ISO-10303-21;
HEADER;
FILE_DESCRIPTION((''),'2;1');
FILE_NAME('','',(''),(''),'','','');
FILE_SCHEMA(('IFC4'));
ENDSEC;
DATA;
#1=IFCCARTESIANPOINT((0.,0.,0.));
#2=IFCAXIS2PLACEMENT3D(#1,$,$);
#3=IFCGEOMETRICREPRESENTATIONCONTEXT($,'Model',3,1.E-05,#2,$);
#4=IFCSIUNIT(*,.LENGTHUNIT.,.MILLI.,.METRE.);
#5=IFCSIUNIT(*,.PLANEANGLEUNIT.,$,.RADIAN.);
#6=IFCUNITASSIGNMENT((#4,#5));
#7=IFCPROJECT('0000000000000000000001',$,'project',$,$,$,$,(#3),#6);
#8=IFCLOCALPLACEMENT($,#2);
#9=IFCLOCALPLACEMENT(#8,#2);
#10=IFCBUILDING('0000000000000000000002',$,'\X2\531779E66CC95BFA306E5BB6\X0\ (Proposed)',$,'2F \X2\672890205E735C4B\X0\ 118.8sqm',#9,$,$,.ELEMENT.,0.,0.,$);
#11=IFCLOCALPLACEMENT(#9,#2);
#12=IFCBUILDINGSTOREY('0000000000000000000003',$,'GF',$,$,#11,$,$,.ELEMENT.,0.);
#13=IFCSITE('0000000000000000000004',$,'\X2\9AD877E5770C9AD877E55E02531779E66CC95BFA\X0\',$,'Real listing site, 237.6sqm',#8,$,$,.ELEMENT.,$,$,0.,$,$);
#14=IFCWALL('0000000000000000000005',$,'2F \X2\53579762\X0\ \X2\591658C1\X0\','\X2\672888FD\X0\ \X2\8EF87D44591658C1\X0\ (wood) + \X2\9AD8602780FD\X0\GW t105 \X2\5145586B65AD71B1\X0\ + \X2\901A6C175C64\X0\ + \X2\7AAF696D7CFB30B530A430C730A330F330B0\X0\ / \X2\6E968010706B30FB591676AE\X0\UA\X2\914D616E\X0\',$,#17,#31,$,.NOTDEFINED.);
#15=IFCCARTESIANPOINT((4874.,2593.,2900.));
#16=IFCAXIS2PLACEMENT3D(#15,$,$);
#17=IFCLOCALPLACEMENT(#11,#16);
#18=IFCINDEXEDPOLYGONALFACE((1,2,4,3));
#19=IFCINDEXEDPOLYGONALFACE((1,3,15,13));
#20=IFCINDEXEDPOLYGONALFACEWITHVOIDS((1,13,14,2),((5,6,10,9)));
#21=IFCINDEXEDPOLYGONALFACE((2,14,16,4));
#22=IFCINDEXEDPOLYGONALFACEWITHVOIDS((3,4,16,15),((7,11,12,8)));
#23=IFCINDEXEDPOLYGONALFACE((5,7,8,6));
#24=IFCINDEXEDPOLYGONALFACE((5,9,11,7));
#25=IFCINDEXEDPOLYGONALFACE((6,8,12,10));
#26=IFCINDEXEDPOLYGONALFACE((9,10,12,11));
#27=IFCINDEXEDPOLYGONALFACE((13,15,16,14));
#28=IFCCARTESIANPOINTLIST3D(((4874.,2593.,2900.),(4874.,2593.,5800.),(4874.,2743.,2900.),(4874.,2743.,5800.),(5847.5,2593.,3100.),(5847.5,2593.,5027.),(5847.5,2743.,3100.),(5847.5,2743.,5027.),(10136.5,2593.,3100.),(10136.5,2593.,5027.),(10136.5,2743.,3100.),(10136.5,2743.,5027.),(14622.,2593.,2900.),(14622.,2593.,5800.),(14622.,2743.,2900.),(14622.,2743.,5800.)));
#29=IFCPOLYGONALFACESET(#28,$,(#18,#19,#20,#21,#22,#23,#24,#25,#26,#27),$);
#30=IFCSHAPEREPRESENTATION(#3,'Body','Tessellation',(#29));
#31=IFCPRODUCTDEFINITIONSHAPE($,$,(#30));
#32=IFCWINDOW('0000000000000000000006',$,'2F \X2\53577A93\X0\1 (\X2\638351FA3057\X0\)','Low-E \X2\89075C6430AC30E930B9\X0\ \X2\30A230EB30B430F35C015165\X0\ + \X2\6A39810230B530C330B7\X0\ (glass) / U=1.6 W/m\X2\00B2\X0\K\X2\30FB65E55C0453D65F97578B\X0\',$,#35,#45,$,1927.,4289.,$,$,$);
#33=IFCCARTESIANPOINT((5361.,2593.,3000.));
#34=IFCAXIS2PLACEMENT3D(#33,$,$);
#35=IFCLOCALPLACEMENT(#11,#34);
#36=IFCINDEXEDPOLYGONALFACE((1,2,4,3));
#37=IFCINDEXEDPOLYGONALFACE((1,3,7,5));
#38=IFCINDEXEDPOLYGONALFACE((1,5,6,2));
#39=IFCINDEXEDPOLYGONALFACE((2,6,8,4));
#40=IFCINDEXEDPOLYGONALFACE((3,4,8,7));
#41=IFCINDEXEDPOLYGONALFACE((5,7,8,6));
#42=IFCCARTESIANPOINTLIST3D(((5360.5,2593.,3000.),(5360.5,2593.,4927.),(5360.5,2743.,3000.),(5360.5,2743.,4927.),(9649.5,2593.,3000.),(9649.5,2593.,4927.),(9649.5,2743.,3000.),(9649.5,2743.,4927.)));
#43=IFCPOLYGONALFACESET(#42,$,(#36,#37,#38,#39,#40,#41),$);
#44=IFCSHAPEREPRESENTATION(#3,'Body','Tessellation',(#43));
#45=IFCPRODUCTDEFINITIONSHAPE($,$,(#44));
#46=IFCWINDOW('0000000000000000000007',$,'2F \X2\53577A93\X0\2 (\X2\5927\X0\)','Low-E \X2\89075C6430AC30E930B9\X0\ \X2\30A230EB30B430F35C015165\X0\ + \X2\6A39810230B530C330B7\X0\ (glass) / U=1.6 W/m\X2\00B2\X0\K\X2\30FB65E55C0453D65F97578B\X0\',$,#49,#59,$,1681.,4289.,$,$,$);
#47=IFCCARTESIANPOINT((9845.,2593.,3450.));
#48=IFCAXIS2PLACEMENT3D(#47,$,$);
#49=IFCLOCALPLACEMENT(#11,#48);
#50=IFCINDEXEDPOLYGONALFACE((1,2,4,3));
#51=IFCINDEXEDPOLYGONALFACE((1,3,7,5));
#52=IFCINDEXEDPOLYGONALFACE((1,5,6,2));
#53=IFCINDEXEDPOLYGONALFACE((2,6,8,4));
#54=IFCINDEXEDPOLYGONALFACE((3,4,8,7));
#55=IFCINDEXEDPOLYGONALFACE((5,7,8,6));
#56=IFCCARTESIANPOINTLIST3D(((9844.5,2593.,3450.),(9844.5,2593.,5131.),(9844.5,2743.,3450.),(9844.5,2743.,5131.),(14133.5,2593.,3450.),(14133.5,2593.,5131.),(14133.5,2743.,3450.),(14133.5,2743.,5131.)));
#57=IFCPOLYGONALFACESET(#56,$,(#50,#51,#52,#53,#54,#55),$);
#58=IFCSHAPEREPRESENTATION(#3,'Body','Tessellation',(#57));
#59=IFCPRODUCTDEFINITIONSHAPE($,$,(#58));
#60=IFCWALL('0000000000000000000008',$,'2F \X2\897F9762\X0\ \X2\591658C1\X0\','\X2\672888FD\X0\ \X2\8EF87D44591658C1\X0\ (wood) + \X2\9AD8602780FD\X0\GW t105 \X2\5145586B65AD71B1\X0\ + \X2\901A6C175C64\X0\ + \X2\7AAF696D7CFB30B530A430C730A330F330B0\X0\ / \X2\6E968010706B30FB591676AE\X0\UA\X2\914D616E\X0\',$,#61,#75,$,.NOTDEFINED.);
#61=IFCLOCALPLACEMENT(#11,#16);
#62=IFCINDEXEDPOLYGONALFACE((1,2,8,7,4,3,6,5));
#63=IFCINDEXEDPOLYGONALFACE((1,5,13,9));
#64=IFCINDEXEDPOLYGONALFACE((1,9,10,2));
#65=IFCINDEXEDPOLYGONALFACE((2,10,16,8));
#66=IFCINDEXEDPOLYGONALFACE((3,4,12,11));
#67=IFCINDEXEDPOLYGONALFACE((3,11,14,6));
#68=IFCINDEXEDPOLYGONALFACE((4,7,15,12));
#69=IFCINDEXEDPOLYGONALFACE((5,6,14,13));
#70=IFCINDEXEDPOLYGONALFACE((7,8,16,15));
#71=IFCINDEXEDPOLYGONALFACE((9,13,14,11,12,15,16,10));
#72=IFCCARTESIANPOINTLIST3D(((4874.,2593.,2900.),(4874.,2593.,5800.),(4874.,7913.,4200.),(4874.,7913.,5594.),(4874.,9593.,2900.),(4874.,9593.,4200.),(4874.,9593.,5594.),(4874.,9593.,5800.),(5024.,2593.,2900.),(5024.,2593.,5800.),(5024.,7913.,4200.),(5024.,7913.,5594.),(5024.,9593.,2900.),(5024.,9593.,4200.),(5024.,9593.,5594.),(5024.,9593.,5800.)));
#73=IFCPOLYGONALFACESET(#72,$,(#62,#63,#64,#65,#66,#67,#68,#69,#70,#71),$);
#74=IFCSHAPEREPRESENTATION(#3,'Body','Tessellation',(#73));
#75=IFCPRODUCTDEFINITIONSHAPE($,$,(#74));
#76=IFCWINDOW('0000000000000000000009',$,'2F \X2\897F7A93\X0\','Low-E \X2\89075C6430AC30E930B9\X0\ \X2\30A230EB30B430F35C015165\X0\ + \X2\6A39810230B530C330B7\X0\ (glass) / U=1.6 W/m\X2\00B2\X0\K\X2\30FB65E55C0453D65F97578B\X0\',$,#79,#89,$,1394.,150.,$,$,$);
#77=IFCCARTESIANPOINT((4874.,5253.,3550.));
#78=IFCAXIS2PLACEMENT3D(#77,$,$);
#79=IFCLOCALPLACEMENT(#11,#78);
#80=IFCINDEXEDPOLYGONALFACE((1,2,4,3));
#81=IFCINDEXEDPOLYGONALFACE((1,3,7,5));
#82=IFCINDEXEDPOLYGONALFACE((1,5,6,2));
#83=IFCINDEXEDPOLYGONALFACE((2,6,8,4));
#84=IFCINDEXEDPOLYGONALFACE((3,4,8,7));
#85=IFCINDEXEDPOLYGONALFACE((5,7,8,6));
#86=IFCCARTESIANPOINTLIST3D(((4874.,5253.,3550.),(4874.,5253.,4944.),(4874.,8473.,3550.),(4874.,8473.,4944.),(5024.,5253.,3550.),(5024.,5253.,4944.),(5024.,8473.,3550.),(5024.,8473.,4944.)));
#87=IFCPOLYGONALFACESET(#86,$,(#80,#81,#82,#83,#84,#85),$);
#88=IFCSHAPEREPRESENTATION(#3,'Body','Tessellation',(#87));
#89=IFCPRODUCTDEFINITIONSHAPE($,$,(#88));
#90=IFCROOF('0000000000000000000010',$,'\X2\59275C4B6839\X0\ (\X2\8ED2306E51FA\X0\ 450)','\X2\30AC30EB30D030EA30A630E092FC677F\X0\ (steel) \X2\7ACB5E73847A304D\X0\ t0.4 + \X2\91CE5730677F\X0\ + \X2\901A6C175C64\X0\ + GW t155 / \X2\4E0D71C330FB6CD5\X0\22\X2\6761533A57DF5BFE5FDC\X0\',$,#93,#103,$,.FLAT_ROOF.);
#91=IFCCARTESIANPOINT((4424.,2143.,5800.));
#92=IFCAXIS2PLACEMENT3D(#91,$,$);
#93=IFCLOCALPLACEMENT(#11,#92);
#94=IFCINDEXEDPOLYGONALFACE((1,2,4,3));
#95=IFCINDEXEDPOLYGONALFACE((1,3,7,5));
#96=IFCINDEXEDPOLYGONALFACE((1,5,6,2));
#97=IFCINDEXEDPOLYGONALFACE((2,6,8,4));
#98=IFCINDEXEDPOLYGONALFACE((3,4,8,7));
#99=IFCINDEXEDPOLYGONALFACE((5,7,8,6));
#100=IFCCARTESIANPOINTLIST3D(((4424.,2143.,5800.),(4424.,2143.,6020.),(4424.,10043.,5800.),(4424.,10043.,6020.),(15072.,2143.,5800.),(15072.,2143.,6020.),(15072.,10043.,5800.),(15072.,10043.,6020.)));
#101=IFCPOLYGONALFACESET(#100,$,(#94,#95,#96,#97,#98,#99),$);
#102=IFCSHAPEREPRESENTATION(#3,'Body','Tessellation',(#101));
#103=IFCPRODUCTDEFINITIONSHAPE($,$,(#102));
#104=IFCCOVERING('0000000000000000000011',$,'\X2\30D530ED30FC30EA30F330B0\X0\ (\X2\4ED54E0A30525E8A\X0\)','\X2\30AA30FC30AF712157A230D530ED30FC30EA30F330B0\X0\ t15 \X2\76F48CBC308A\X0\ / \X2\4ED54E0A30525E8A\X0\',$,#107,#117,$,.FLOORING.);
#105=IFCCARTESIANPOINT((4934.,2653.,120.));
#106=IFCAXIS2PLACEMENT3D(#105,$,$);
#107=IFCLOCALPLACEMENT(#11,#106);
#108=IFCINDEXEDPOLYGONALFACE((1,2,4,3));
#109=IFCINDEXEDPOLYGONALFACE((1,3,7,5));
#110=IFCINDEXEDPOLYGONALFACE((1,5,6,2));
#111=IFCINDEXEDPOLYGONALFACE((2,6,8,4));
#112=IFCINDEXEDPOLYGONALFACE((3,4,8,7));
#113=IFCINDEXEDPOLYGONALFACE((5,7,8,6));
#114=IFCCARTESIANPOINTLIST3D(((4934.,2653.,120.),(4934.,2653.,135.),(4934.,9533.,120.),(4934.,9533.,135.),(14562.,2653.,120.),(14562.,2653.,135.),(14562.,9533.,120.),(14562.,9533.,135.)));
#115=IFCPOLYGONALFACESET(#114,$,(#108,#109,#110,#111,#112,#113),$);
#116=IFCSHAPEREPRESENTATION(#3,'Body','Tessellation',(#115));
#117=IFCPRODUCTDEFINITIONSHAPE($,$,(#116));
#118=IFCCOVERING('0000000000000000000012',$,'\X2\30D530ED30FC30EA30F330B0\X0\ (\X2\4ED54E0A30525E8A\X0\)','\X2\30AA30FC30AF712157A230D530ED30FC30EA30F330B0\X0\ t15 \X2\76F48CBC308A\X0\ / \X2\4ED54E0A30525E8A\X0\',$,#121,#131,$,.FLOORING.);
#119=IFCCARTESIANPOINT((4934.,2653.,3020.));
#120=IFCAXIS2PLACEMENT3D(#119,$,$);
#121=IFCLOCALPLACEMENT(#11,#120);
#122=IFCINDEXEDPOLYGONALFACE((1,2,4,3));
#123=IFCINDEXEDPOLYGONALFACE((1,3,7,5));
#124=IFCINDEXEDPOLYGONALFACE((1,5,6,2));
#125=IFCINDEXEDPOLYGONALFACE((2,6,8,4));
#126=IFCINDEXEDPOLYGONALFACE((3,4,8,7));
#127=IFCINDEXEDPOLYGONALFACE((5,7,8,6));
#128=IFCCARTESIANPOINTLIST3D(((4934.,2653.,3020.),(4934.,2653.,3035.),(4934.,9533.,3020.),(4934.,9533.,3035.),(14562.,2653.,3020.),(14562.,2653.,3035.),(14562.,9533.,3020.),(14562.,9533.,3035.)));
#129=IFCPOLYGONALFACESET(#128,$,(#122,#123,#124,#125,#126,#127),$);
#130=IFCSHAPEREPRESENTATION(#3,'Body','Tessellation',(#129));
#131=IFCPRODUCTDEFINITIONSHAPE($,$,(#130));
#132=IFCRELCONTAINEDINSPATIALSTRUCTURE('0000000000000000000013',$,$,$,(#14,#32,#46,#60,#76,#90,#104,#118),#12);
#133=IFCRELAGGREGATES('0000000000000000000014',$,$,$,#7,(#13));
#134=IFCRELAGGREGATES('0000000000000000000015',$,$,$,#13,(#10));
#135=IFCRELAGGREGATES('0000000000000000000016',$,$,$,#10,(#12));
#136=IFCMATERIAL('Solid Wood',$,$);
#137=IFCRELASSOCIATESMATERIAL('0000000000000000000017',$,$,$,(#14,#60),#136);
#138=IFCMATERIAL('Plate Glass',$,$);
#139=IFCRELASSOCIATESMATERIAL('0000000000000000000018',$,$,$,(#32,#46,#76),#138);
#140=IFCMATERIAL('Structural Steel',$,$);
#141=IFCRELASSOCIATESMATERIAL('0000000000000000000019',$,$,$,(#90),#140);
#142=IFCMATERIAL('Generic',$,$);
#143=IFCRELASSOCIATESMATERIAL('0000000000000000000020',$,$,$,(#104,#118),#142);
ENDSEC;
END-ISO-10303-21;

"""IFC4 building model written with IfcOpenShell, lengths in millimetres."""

from ifc_helpers import new_model, si_unit, frame, frame_2d, origin, place, context, project, spatial, rectangle, extrude, material, element, fill, save


model = new_model("IFC4")

# Units and contexts
model_context = context("Model", 3, precision=1e-05, world=origin())
ifc_project = project(units=[si_unit("LENGTHUNIT", "METRE", prefix="MILLI"), si_unit("PLANEANGLEUNIT", "RADIAN")], contexts=[model_context])

# Site, building, storey
site_placement = place(None, origin())
site = spatial("IfcSite", under=ifc_project, at=site_placement, Name="高知県高知市北秦泉寺", ObjectType="Real listing site, 237.6sqm", CompositionType="ELEMENT", RefElevation=0.0)
building_placement = place(site_placement, origin())
building = spatial("IfcBuilding", under=site, at=building_placement, Name="北秦泉寺の家 (Proposed)", ObjectType="2F 木造平屋 118.8sqm", CompositionType="ELEMENT", ElevationOfRefHeight=0.0, ElevationOfTerrain=0.0)
storey_placement = place(building_placement, origin())
storey = spatial("IfcBuildingStorey", under=building, at=storey_placement, Name="GF", CompositionType="ELEMENT", Elevation=0.0)

# Shared definitions
ifc_material_1 = material(Name="Solid Wood")

# Shared definitions
ifc_material_2 = material(Name="Plate Glass")

# Wall, openings, windows
wall_1_placement = place(storey_placement, frame((4874.0, 2593.0, 2900.0)))
wall_1 = element("IfcWall", 1, at=wall_1_placement, inside=storey, material=ifc_material_1, Name="2F 南面 外壁", Description="木製 軸組外壁 (wood) + 高性能GW t105 充填断熱 + 通気層 + 窯業系サイディング / 準耐火・外皮UA配慮", PredefinedType="NOTDEFINED", context=model_context, shape_type="SweptSolid", body=[
    extrude(rectangle(XDim=9748.0, YDim=150.0, at=frame_2d((4874.0, 75.0))), frame((4874.0, 2593.0, 2900.0)), (0.0, 0.0, 1.0), 2900.0),
])
opening_1_placement = place(storey_placement, frame((5361.0, 2593.0, 3000.0)))
opening_1 = element("IfcOpeningElement", 2, at=opening_1_placement, cuts=wall_1, PredefinedType="NOTDEFINED", context=model_context, shape_type="SweptSolid", body=[
    extrude(rectangle(XDim=4289.0, YDim=150.0, at=frame_2d((2144.0, 75.0))), frame((5361.0, 2593.0, 3000.0)), (0.0, 0.0, 1.0), 1927.0),
])
opening_2_placement = place(storey_placement, frame((9845.0, 2593.0, 3450.0)))
opening_2 = element("IfcOpeningElement", 3, at=opening_2_placement, cuts=wall_1, PredefinedType="NOTDEFINED", context=model_context, shape_type="SweptSolid", body=[
    extrude(rectangle(XDim=4289.0, YDim=150.0, at=frame_2d((2144.0, 75.0))), frame((9845.0, 2593.0, 3450.0)), (0.0, 0.0, 1.0), 1681.0),
])
window_1_placement = place(storey_placement, frame((5361.0, 2593.0, 3000.0)))
window_1 = element("IfcWindow", 4, at=window_1_placement, inside=storey, material=ifc_material_2, Name="2F 南窓1 (掃出し)", Description="Low-E 複層ガラス アルゴン封入 + 樹脂サッシ (glass) / U=1.6 W/m²K・日射取得型", OverallHeight=1927.0, OverallWidth=4289.0, context=model_context, shape_type="SweptSolid", body=[
    extrude(rectangle(XDim=4289.0, YDim=150.0, at=frame_2d((2144.0, 75.0))), frame((5361.0, 2593.0, 3000.0)), (0.0, 0.0, 1.0), 1927.0),
])
fill(opening_1, window_1)
window_2_placement = place(storey_placement, frame((9845.0, 2593.0, 3450.0)))
window_2 = element("IfcWindow", 5, at=window_2_placement, inside=storey, material=ifc_material_2, Name="2F 南窓2 (大)", Description="Low-E 複層ガラス アルゴン封入 + 樹脂サッシ (glass) / U=1.6 W/m²K・日射取得型", OverallHeight=1681.0, OverallWidth=4289.0, context=model_context, shape_type="SweptSolid", body=[
    extrude(rectangle(XDim=4289.0, YDim=150.0, at=frame_2d((2144.0, 75.0))), frame((9845.0, 2593.0, 3450.0)), (0.0, 0.0, 1.0), 1681.0),
])
fill(opening_2, window_2)

# Wall, opening, window
wall_2_placement = place(storey_placement, frame((4874.0, 2593.0, 2900.0)))
wall_2 = element("IfcWall", 6, at=wall_2_placement, inside=storey, material=ifc_material_1, Name="2F 西面 外壁", Description="木製 軸組外壁 (wood) + 高性能GW t105 充填断熱 + 通気層 + 窯業系サイディング / 準耐火・外皮UA配慮", PredefinedType="NOTDEFINED", context=model_context, shape_type="SweptSolid", body=[
    extrude(rectangle(XDim=150.0, YDim=7000.0, at=frame_2d((75.0, 3500.0))), frame((4874.0, 2593.0, 2900.0)), (0.0, 0.0, 1.0), 2900.0),
])
opening_3_placement = place(storey_placement, frame((4874.0, 5253.0, 3550.0)))
opening_3 = element("IfcOpeningElement", 7, at=opening_3_placement, cuts=wall_2, PredefinedType="NOTDEFINED", context=model_context, shape_type="SweptSolid", body=[
    extrude(rectangle(XDim=150.0, YDim=3220.0, at=frame_2d((75.0, 1610.0))), frame((4874.0, 5253.0, 3550.0)), (0.0, 0.0, 1.0), 1394.0),
])
window_3_placement = place(storey_placement, frame((4874.0, 5253.0, 3550.0)))
window_3 = element("IfcWindow", 8, at=window_3_placement, inside=storey, material=ifc_material_2, Name="2F 西窓", Description="Low-E 複層ガラス アルゴン封入 + 樹脂サッシ (glass) / U=1.6 W/m²K・日射取得型", OverallHeight=1394.0, OverallWidth=150.0, context=model_context, shape_type="SweptSolid", body=[
    extrude(rectangle(XDim=150.0, YDim=3220.0, at=frame_2d((75.0, 1610.0))), frame((4874.0, 5253.0, 3550.0)), (0.0, 0.0, 1.0), 1394.0),
])
fill(opening_3, window_3)

# Roof
ifc_material_3 = material(Name="Structural Steel")
roof_placement = place(storey_placement, frame((4424.0, 2143.0, 5800.0)))
element("IfcRoof", 9, at=roof_placement, inside=storey, material=ifc_material_3, Name="大屋根 (軒の出 450)", Description="ガルバリウム鋼板 (steel) 立平葺き t0.4 + 野地板 + 通気層 + GW t155 / 不燃・法22条区域対応", PredefinedType="FLAT_ROOF", context=model_context, shape_type="SweptSolid", body=[
    extrude(rectangle(XDim=10648.0, YDim=7900.0, at=frame_2d((5324.0, 3950.0))), frame((4424.0, 2143.0, 5800.0)), (0.0, 0.0, 1.0), 220.0),
])

# Coverings
ifc_material_4 = material(Name="Generic")
covering_1_placement = place(storey_placement, frame((4934.0, 2653.0, 120.0)))
element("IfcCovering", 10, at=covering_1_placement, inside=storey, material=ifc_material_4, Name="フローリング (仕上げ床)", Description="オーク無垢フローリング t15 直貼り / 仕上げ床", PredefinedType="FLOORING", context=model_context, shape_type="SweptSolid", body=[
    extrude(rectangle(XDim=9628.0, YDim=6880.0, at=frame_2d((4814.0, 3440.0))), frame((4934.0, 2653.0, 120.0)), (0.0, 0.0, 1.0), 15.0),
])
covering_2_placement = place(storey_placement, frame((4934.0, 2653.0, 3020.0)))
element("IfcCovering", 11, at=covering_2_placement, inside=storey, material=ifc_material_4, Name="フローリング (仕上げ床)", Description="オーク無垢フローリング t15 直貼り / 仕上げ床", PredefinedType="FLOORING", context=model_context, shape_type="SweptSolid", body=[
    extrude(rectangle(XDim=9628.0, YDim=6880.0, at=frame_2d((4814.0, 3440.0))), frame((4934.0, 2653.0, 3020.0)), (0.0, 0.0, 1.0), 15.0),
])

save(model, "model.ifc")
